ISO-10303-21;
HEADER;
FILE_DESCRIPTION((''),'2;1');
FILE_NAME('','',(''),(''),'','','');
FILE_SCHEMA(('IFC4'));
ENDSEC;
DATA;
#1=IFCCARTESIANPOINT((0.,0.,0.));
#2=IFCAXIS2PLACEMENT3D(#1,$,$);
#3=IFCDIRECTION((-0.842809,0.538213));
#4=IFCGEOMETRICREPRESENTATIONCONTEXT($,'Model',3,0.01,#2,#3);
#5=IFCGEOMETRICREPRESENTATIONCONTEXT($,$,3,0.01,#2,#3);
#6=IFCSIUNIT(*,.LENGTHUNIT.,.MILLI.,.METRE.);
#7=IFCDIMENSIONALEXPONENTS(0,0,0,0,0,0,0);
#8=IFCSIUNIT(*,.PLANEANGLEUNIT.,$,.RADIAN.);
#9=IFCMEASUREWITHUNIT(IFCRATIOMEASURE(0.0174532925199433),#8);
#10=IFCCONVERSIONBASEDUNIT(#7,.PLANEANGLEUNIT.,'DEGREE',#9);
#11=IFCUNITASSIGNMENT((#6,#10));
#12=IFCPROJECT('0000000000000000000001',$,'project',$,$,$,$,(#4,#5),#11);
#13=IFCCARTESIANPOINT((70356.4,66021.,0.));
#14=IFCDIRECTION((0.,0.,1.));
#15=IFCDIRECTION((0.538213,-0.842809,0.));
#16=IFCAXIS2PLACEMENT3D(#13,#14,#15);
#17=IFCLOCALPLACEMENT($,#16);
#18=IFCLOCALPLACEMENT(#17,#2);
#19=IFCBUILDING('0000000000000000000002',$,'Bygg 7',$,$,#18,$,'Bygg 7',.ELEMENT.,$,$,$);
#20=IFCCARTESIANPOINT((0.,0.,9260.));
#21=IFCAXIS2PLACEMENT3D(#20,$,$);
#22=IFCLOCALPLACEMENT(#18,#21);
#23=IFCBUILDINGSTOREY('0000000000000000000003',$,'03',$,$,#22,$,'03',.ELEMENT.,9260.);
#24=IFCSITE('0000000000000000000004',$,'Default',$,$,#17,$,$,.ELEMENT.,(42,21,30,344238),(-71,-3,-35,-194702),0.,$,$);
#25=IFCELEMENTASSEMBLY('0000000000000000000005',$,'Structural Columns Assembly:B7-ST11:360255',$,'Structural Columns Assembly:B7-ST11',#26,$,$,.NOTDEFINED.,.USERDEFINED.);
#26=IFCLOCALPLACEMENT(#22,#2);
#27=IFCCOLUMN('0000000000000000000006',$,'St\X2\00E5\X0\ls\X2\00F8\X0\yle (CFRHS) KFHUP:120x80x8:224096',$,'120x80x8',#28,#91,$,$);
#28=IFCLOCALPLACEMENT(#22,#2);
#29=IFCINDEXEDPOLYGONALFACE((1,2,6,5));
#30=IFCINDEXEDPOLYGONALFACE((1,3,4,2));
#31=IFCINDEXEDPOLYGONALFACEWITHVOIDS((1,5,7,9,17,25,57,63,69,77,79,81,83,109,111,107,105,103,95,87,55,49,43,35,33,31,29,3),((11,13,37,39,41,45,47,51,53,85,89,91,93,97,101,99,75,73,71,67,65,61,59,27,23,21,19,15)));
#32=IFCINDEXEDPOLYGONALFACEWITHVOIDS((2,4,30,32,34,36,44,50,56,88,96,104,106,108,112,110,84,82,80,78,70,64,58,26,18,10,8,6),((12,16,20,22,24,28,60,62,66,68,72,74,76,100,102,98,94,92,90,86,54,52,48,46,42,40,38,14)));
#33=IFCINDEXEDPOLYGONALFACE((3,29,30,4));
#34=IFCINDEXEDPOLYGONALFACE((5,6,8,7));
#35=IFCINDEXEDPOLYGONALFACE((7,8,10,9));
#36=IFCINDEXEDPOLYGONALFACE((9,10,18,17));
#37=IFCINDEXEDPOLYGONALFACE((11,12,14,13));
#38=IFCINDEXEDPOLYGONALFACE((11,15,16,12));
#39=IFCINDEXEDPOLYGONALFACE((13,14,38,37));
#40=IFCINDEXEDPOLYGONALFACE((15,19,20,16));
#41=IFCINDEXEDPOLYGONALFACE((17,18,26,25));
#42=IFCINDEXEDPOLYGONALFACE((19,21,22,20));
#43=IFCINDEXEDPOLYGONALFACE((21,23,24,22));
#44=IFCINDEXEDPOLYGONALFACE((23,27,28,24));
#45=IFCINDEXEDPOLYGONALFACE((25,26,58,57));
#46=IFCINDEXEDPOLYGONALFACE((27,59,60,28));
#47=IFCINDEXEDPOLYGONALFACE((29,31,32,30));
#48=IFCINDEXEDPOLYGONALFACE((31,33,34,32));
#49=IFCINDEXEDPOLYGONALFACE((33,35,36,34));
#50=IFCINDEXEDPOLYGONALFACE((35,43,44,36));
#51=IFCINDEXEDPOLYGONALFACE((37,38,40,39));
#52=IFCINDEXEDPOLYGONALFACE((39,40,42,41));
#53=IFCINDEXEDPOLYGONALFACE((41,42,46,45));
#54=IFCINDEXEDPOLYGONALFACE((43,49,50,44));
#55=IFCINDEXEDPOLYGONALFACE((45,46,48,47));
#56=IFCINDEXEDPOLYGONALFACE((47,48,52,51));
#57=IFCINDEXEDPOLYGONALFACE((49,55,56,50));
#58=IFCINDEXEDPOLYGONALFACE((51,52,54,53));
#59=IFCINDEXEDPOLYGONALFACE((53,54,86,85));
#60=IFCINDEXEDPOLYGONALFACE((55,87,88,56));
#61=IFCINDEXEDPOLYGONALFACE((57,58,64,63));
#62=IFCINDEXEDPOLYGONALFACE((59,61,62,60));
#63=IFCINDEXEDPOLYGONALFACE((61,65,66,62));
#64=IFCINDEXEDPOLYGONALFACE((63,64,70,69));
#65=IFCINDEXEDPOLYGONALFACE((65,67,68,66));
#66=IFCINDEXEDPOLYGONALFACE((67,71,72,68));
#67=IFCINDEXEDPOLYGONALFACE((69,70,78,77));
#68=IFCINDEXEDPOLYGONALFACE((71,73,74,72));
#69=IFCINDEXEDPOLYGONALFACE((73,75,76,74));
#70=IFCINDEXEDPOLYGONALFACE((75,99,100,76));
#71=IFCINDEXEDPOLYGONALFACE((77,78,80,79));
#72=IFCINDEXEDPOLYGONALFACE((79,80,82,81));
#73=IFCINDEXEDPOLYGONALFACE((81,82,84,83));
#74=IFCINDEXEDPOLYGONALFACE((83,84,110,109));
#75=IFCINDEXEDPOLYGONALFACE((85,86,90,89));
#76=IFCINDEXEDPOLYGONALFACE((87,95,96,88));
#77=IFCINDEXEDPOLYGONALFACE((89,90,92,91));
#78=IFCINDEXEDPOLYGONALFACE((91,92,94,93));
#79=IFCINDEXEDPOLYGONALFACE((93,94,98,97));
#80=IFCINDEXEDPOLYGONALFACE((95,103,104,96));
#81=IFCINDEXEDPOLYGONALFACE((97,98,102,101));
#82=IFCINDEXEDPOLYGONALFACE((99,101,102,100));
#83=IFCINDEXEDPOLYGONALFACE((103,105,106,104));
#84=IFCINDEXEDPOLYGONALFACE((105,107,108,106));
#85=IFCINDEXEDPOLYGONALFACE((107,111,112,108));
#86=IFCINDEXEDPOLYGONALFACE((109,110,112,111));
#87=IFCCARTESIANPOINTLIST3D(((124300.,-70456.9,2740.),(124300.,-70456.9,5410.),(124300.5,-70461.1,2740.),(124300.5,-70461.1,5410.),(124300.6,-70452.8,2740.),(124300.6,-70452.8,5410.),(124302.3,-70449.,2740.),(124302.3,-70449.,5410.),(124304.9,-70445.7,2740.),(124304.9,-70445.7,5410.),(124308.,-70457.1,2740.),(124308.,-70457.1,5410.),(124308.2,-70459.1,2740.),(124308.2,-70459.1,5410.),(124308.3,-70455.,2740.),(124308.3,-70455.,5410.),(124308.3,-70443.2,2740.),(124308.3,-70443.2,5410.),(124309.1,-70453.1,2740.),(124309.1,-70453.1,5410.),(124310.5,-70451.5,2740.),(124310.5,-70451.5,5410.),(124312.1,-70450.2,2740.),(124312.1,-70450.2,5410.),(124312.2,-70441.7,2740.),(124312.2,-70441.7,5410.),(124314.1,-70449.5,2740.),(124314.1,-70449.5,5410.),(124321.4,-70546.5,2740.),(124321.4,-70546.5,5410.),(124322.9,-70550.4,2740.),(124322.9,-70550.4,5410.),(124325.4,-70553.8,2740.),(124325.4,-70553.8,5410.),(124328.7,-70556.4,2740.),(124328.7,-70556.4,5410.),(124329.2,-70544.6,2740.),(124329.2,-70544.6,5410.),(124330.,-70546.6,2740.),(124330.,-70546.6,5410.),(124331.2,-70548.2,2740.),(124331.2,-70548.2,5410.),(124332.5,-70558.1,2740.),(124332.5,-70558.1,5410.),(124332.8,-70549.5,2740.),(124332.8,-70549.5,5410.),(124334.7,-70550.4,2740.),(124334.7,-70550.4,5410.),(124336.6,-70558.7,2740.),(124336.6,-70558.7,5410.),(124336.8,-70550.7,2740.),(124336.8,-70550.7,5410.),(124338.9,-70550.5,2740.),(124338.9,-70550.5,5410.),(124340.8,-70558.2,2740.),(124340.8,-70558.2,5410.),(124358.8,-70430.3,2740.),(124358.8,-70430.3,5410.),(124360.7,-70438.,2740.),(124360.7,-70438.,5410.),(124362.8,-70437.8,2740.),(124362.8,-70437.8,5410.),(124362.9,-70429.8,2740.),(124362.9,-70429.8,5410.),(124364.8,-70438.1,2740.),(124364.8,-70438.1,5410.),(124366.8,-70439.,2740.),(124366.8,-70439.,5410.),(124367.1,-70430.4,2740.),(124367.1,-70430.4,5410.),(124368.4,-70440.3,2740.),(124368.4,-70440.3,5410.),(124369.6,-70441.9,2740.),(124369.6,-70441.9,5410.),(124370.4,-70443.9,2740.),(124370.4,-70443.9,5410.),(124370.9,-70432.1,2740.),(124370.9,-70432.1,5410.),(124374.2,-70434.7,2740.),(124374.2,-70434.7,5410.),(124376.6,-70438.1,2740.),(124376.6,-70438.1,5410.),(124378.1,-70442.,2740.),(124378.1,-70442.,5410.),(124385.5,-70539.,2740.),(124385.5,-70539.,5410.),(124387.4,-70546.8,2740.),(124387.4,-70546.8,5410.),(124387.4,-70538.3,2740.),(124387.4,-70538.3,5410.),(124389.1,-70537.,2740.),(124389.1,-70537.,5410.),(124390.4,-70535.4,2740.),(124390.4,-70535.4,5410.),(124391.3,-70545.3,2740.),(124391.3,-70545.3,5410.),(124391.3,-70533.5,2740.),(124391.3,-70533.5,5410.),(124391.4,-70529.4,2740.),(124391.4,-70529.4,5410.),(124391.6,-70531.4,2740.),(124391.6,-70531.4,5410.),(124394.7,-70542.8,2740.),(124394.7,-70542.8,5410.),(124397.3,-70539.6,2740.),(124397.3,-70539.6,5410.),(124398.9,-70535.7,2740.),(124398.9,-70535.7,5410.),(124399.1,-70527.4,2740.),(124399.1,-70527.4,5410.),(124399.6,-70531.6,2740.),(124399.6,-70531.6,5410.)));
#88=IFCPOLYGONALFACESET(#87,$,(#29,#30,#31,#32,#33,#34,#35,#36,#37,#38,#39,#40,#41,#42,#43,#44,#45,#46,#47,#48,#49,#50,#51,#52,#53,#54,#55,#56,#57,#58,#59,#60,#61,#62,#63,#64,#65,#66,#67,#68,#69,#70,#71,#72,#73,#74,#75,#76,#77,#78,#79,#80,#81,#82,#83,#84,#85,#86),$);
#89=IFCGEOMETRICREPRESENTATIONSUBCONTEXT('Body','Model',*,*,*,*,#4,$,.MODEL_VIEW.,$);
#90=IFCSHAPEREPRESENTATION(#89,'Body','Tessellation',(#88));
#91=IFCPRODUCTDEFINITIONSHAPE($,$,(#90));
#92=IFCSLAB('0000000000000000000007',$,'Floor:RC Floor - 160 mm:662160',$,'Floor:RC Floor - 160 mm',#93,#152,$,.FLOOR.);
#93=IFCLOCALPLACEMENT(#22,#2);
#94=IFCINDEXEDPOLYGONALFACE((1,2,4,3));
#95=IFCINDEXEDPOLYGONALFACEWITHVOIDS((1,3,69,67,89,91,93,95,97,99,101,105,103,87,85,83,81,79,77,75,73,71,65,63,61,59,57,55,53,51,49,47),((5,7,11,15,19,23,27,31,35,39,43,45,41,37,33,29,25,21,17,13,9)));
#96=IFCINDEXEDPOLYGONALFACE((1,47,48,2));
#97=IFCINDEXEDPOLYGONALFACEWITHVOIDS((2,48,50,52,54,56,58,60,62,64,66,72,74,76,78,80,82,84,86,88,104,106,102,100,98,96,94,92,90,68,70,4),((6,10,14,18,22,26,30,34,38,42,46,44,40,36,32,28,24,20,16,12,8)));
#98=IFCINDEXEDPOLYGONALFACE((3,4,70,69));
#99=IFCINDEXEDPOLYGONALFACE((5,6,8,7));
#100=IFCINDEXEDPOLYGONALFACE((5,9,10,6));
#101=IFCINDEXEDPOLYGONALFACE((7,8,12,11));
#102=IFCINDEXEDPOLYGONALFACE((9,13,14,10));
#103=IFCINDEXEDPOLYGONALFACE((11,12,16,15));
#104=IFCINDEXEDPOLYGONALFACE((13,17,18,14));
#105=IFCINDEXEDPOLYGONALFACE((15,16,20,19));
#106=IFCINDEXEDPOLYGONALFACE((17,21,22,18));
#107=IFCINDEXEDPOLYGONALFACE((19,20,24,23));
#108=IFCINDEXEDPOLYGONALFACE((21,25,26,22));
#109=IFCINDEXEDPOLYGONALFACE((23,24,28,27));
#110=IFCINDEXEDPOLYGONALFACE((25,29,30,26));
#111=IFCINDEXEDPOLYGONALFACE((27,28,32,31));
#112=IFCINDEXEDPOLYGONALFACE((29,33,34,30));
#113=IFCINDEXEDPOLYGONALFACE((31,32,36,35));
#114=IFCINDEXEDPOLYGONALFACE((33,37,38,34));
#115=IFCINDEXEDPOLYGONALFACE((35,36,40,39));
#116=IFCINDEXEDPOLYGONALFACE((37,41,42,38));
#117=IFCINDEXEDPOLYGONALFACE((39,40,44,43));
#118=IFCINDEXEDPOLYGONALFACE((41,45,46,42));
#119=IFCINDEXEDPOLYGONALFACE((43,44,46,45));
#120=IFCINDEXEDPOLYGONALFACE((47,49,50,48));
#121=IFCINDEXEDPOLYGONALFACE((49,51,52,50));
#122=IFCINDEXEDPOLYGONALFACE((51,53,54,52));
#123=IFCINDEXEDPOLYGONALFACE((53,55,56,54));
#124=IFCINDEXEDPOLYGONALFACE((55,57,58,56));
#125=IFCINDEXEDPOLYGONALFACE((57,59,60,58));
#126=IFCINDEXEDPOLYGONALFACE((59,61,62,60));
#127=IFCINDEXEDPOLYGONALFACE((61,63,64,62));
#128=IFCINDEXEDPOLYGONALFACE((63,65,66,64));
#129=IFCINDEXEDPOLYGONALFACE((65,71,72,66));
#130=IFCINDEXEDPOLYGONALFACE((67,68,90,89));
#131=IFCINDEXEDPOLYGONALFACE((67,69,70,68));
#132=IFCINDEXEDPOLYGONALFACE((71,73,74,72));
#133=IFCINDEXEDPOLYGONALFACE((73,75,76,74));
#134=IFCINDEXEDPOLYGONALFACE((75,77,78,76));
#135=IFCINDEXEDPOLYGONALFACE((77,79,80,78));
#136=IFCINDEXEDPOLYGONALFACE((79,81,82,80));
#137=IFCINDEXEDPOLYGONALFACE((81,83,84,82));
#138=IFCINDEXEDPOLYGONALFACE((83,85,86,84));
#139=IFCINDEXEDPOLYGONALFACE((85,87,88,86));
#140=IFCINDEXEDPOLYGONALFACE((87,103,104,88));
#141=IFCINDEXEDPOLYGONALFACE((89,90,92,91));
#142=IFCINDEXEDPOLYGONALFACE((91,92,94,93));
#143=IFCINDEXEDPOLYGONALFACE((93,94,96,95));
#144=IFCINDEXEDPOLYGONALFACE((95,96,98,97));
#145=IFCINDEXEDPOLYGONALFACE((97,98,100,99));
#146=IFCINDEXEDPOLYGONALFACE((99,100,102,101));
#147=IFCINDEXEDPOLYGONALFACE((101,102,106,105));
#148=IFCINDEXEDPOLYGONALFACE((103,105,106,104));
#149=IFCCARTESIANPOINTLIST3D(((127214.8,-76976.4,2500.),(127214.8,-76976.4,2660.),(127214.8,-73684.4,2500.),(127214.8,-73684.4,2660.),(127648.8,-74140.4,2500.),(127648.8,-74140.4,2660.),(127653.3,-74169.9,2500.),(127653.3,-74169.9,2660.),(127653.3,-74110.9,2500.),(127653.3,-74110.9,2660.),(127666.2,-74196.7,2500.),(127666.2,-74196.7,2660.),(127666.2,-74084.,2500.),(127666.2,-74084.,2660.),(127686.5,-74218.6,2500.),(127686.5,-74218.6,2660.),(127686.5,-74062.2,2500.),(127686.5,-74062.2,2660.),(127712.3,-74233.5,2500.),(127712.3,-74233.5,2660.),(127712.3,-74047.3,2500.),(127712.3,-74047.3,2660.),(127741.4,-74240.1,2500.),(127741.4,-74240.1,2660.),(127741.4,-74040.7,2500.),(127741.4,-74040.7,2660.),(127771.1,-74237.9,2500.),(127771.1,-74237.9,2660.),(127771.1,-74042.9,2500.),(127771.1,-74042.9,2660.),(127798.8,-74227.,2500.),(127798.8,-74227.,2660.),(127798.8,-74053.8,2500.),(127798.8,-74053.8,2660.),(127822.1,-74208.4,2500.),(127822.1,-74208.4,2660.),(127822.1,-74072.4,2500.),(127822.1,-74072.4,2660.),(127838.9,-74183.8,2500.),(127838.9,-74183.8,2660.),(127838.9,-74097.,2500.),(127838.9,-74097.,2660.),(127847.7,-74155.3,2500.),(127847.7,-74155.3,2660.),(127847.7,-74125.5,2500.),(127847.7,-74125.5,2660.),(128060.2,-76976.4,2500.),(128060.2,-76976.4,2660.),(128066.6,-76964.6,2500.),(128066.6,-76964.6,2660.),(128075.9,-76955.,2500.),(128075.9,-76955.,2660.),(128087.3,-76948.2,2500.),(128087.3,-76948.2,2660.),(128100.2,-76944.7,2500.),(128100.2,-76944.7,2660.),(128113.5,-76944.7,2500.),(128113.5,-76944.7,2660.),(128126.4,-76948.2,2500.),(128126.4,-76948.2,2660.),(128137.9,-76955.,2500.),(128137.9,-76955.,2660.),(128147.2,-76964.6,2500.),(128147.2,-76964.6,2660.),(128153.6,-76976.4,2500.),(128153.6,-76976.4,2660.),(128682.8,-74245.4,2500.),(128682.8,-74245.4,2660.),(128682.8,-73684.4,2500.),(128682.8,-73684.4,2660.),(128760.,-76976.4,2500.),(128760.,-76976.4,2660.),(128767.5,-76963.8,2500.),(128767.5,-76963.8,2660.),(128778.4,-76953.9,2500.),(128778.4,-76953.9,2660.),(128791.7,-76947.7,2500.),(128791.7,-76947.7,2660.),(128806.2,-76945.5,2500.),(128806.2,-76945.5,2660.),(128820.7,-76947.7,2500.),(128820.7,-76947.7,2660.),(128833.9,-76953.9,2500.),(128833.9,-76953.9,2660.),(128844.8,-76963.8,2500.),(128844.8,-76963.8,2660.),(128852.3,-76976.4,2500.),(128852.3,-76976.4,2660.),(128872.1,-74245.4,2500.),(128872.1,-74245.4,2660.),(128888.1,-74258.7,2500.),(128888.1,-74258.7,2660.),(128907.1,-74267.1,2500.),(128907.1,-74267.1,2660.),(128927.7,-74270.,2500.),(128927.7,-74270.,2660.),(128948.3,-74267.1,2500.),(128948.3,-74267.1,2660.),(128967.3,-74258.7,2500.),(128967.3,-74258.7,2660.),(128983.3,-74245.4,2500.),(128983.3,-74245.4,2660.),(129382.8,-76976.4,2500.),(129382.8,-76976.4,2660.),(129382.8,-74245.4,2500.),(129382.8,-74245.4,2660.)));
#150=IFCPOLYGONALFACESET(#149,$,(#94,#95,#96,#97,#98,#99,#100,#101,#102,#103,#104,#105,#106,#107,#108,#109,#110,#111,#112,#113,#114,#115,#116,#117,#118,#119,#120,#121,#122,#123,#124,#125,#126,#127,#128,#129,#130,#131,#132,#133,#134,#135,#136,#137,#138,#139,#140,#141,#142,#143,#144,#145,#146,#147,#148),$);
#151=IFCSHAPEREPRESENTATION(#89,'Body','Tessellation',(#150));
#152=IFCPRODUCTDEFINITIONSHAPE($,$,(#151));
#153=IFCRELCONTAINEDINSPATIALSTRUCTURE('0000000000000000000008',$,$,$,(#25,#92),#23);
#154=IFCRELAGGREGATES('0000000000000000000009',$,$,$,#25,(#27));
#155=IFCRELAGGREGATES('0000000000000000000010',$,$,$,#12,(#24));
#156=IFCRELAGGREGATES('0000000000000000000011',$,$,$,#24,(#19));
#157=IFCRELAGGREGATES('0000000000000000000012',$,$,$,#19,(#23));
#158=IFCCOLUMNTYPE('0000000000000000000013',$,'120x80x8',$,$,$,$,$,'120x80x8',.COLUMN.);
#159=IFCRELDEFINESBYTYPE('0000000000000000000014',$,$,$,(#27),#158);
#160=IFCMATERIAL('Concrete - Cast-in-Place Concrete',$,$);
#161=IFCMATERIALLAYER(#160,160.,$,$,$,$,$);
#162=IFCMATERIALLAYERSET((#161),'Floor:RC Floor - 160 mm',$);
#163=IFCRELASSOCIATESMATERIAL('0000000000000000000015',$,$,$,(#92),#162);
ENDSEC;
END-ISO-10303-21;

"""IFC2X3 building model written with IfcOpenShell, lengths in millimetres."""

from ifc_helpers import new_model, entity, si_unit, converted_unit, direction, frame, frame_2d, origin, place, context, subcontext, project, spatial, polyline, circle_curve, parameter, trimmed, segment, composite_curve, circle, outline, extrude, source, transform, mapped, material, layer, layer_set, layer_usage, type_object, type_shapes, element, aggregate, save


model = new_model("IFC2X3")

# Units and contexts
model_context = context("Model", 3, precision=0.01, world=origin(), true_north=direction((-0.842809, 0.538213)))
context_of_model = context(None, 3, precision=0.01, world=origin(), true_north=direction((-0.842809, 0.538213)))
body_context = subcontext(model_context, "Body", "Model", "MODEL_VIEW")
ifc_project = project(units=[si_unit("LENGTHUNIT", "METRE", prefix="MILLI"), converted_unit("PLANEANGLEUNIT", "DEGREE", entity("IfcRatioMeasure", 0.0174532925199433), si_unit("PLANEANGLEUNIT", "RADIAN"), dimensions=[0, 0, 0, 0, 0, 0, 0])], contexts=[model_context, context_of_model])

# Site, building, storey
site_placement = place(None, frame((70356.4, 66021.0, 0.0), z_axis=(0.0, 0.0, 1.0), x_axis=(0.538213, -0.842809, 0.0)))
site = spatial("IfcSite", under=ifc_project, at=site_placement, Name="Default", CompositionType="ELEMENT", RefLatitude=(42, 21, 30, 344238), RefLongitude=(-71, -3, -35, -194702), RefElevation=0.0)
building_placement = place(site_placement, origin())
building = spatial("IfcBuilding", under=site, at=building_placement, Name="Bygg 7", LongName="Bygg 7", CompositionType="ELEMENT")
storey_placement = place(building_placement, frame((0.0, 0.0, 9260.0)))
storey = spatial("IfcBuildingStorey", under=building, at=storey_placement, Name="03", LongName="03", CompositionType="ELEMENT", Elevation=9260.0)

# Element assembly, column
assembly_1_placement = place(storey_placement, origin())
assembly_1 = element("IfcElementAssembly", 1, at=assembly_1_placement, inside=storey, Name="Structural Columns Assembly:B7-ST11:360255", ObjectType="Structural Columns Assembly:B7-ST11", AssemblyPlace="NOTDEFINED", PredefinedType="USERDEFINED")
column_type_1 = type_object("IfcColumnType", Name="120x80x8", ElementType="120x80x8", PredefinedType="COLUMN")
shared_shape_1 = source(origin(), body_context, "Body", "SweptSolid", [
    extrude(outline(composite_curve([segment(trimmed(circle_curve(frame_2d((-24.0, 44.0), x_axis=(1.0, 0.0)), 16.0), [parameter(90.0)], [parameter(180.0)], True, "PARAMETER"), True, "CONTINUOUS"), segment(polyline([(-40.0, 44.0), (-40.0, -44.0)]), True, "CONTINUOUS"), segment(trimmed(circle_curve(frame_2d((-24.0, -44.0), x_axis=(1.0, 0.0)), 16.0), [parameter(180.0)], [parameter(270.0)], True, "PARAMETER"), True, "CONTINUOUS"), segment(polyline([(-24.0, -60.0), (24.0, -60.0)]), True, "CONTINUOUS"), segment(trimmed(circle_curve(frame_2d((24.0, -44.0), x_axis=(1.0, 0.0)), 16.0), [parameter(270.0)], [parameter(0.0)], True, "PARAMETER"), True, "CONTINUOUS"), segment(polyline([(40.0, -44.0), (40.0, 44.0)]), True, "CONTINUOUS"), segment(trimmed(circle_curve(frame_2d((24.0, 44.0), x_axis=(1.0, 0.0)), 16.0), [parameter(0.0)], [parameter(90.0)], True, "PARAMETER"), True, "CONTINUOUS"), segment(polyline([(24.0, 60.0), (-24.0, 60.0)]), True, "CONTINUOUS")], self_intersect=False), holes=[composite_curve([segment(polyline([(-24.0, 52.0), (24.0, 52.0)]), True, "CONTINUOUS"), segment(trimmed(circle_curve(frame_2d((24.0, 44.0), x_axis=(1.0, 0.0)), 8.0), [parameter(360.0)], [parameter(90.0)], True, "PARAMETER"), False, "CONTINUOUS"), segment(polyline([(32.0, 44.0), (32.0, -44.0)]), True, "CONTINUOUS"), segment(trimmed(circle_curve(frame_2d((24.0, -44.0), x_axis=(1.0, 0.0)), 8.0), [parameter(270.0)], [parameter(360.0)], True, "PARAMETER"), False, "CONTINUOUS"), segment(polyline([(24.0, -52.0), (-24.0, -52.0)]), True, "CONTINUOUS"), segment(trimmed(circle_curve(frame_2d((-24.0, -44.0), x_axis=(1.0, 0.0)), 8.0), [parameter(180.0)], [parameter(270.0)], True, "PARAMETER"), False, "CONTINUOUS"), segment(polyline([(-32.0, -44.0), (-32.0, 44.0)]), True, "CONTINUOUS"), segment(trimmed(circle_curve(frame_2d((-24.0, 44.0), x_axis=(1.0, 0.0)), 8.0), [parameter(90.0)], [parameter(180.0)], True, "PARAMETER"), False, "CONTINUOUS")], self_intersect=False)]), frame((51.4, 66.0, 0.0), z_axis=(0.0, 0.0, 1.0), x_axis=(-0.971172, -0.238381, 0.0)), (0.0, 0.0, 1.0), 2670.0),
])
type_shapes(column_type_1, [shared_shape_1])
column_1_placement = place(assembly_1_placement, frame((124298.4, -70560.3, 2740.0)))
column_1 = element("IfcColumn", 2, at=column_1_placement, type_object=column_type_1, Name="Stålsøyle (CFRHS) KFHUP:120x80x8:224096", ObjectType="120x80x8", context=body_context, shape_type="MappedRepresentation", body=[
    mapped(shared_shape_1, transform((0.0, 0.0, 0.0), scale=1.0)),
])
aggregate(assembly_1, [column_1])

# Shared definitions
ifc_material_1 = material(Name="Concrete - Cast-in-Place Concrete")

# Slab, openings
ifc_layer_1 = layer(ifc_material_1, 160.0)
ifc_layer_set_1 = layer_set([ifc_layer_1], Name="Floor:RC Floor - 160 mm")
ifc_layer_usage_1 = layer_usage(ifc_layer_set_1, "AXIS3", "POSITIVE", 0.0)
slab_1_placement = place(storey_placement, frame((127214.8, -76976.4, 2500.0)))
slab_1 = element("IfcSlab", 3, at=slab_1_placement, inside=storey, material=ifc_layer_usage_1, Name="Floor:RC Floor - 160 mm:662160", ObjectType="Floor:RC Floor - 160 mm", PredefinedType="FLOOR", context=body_context, shape_type="SweptSolid", body=[
    extrude(outline(polyline([(-384.0, 1646.0), (-384.0, 1085.0), (-1084.0, 1085.0), (-1084.0, -1646.0), (1084.0, -1646.0), (1084.0, 1646.0), (-384.0, 1646.0)])), frame((1084.0, 1646.0, 160.0), z_axis=(0.0, 0.0, -1.0), x_axis=(-1.0, 0.0, 0.0)), (0.0, 0.0, 1.0), 160.0),
])
opening_1_placement = place(storey_placement, frame((127214.8, -76976.4, 2500.0)))
element("IfcOpeningElement", 4, at=opening_1_placement, cuts=slab_1, ObjectType="Opening", context=body_context, shape_type="SweptSolid", body=[
    extrude(circle(Radius=100.0, at=frame_2d((550.0, 1190.0), x_axis=(1.0, 0.0))), frame((1084.0, 1646.0, 160.0), z_axis=(0.0, 0.0, -1.0), x_axis=(-1.0, 0.0, 0.0)), (0.0, 0.0, 1.0), 160.0),
])
opening_2_placement = place(storey_placement, frame((127214.8, -76976.4, 2500.0)))
element("IfcOpeningElement", 5, at=opening_2_placement, cuts=slab_1, ObjectType="Opening", context=body_context, shape_type="SweptSolid", body=[
    extrude(circle(Radius=75.0, at=frame_2d((-628.9, 1135.3), x_axis=(1.0, 0.0))), frame((1084.0, 1646.0, 160.0), z_axis=(0.0, 0.0, -1.0), x_axis=(-1.0, 0.0, 0.0)), (0.0, 0.0, 1.0), 160.0),
])
opening_3_placement = place(storey_placement, frame((127214.8, -76976.4, 2500.0)))
element("IfcOpeningElement", 6, at=opening_3_placement, cuts=slab_1, ObjectType="Opening", context=body_context, shape_type="SweptSolid", body=[
    extrude(circle(Radius=50.0, at=frame_2d((192.0, -1663.9), x_axis=(1.0, 0.0))), frame((1084.0, 1646.0, 160.0), z_axis=(0.0, 0.0, -1.0), x_axis=(-1.0, 0.0, 0.0)), (0.0, 0.0, 1.0), 160.0),
])
opening_4_placement = place(storey_placement, frame((127214.8, -76976.4, 2500.0)))
element("IfcOpeningElement", 7, at=opening_4_placement, cuts=slab_1, ObjectType="Opening", context=body_context, shape_type="SweptSolid", body=[
    extrude(circle(Radius=50.0, at=frame_2d((-507.3, -1665.2), x_axis=(1.0, 0.0))), frame((1084.0, 1646.0, 160.0), z_axis=(0.0, 0.0, -1.0), x_axis=(-1.0, 0.0, 0.0)), (0.0, 0.0, 1.0), 160.0),
])

save(model, "model.ifc")
